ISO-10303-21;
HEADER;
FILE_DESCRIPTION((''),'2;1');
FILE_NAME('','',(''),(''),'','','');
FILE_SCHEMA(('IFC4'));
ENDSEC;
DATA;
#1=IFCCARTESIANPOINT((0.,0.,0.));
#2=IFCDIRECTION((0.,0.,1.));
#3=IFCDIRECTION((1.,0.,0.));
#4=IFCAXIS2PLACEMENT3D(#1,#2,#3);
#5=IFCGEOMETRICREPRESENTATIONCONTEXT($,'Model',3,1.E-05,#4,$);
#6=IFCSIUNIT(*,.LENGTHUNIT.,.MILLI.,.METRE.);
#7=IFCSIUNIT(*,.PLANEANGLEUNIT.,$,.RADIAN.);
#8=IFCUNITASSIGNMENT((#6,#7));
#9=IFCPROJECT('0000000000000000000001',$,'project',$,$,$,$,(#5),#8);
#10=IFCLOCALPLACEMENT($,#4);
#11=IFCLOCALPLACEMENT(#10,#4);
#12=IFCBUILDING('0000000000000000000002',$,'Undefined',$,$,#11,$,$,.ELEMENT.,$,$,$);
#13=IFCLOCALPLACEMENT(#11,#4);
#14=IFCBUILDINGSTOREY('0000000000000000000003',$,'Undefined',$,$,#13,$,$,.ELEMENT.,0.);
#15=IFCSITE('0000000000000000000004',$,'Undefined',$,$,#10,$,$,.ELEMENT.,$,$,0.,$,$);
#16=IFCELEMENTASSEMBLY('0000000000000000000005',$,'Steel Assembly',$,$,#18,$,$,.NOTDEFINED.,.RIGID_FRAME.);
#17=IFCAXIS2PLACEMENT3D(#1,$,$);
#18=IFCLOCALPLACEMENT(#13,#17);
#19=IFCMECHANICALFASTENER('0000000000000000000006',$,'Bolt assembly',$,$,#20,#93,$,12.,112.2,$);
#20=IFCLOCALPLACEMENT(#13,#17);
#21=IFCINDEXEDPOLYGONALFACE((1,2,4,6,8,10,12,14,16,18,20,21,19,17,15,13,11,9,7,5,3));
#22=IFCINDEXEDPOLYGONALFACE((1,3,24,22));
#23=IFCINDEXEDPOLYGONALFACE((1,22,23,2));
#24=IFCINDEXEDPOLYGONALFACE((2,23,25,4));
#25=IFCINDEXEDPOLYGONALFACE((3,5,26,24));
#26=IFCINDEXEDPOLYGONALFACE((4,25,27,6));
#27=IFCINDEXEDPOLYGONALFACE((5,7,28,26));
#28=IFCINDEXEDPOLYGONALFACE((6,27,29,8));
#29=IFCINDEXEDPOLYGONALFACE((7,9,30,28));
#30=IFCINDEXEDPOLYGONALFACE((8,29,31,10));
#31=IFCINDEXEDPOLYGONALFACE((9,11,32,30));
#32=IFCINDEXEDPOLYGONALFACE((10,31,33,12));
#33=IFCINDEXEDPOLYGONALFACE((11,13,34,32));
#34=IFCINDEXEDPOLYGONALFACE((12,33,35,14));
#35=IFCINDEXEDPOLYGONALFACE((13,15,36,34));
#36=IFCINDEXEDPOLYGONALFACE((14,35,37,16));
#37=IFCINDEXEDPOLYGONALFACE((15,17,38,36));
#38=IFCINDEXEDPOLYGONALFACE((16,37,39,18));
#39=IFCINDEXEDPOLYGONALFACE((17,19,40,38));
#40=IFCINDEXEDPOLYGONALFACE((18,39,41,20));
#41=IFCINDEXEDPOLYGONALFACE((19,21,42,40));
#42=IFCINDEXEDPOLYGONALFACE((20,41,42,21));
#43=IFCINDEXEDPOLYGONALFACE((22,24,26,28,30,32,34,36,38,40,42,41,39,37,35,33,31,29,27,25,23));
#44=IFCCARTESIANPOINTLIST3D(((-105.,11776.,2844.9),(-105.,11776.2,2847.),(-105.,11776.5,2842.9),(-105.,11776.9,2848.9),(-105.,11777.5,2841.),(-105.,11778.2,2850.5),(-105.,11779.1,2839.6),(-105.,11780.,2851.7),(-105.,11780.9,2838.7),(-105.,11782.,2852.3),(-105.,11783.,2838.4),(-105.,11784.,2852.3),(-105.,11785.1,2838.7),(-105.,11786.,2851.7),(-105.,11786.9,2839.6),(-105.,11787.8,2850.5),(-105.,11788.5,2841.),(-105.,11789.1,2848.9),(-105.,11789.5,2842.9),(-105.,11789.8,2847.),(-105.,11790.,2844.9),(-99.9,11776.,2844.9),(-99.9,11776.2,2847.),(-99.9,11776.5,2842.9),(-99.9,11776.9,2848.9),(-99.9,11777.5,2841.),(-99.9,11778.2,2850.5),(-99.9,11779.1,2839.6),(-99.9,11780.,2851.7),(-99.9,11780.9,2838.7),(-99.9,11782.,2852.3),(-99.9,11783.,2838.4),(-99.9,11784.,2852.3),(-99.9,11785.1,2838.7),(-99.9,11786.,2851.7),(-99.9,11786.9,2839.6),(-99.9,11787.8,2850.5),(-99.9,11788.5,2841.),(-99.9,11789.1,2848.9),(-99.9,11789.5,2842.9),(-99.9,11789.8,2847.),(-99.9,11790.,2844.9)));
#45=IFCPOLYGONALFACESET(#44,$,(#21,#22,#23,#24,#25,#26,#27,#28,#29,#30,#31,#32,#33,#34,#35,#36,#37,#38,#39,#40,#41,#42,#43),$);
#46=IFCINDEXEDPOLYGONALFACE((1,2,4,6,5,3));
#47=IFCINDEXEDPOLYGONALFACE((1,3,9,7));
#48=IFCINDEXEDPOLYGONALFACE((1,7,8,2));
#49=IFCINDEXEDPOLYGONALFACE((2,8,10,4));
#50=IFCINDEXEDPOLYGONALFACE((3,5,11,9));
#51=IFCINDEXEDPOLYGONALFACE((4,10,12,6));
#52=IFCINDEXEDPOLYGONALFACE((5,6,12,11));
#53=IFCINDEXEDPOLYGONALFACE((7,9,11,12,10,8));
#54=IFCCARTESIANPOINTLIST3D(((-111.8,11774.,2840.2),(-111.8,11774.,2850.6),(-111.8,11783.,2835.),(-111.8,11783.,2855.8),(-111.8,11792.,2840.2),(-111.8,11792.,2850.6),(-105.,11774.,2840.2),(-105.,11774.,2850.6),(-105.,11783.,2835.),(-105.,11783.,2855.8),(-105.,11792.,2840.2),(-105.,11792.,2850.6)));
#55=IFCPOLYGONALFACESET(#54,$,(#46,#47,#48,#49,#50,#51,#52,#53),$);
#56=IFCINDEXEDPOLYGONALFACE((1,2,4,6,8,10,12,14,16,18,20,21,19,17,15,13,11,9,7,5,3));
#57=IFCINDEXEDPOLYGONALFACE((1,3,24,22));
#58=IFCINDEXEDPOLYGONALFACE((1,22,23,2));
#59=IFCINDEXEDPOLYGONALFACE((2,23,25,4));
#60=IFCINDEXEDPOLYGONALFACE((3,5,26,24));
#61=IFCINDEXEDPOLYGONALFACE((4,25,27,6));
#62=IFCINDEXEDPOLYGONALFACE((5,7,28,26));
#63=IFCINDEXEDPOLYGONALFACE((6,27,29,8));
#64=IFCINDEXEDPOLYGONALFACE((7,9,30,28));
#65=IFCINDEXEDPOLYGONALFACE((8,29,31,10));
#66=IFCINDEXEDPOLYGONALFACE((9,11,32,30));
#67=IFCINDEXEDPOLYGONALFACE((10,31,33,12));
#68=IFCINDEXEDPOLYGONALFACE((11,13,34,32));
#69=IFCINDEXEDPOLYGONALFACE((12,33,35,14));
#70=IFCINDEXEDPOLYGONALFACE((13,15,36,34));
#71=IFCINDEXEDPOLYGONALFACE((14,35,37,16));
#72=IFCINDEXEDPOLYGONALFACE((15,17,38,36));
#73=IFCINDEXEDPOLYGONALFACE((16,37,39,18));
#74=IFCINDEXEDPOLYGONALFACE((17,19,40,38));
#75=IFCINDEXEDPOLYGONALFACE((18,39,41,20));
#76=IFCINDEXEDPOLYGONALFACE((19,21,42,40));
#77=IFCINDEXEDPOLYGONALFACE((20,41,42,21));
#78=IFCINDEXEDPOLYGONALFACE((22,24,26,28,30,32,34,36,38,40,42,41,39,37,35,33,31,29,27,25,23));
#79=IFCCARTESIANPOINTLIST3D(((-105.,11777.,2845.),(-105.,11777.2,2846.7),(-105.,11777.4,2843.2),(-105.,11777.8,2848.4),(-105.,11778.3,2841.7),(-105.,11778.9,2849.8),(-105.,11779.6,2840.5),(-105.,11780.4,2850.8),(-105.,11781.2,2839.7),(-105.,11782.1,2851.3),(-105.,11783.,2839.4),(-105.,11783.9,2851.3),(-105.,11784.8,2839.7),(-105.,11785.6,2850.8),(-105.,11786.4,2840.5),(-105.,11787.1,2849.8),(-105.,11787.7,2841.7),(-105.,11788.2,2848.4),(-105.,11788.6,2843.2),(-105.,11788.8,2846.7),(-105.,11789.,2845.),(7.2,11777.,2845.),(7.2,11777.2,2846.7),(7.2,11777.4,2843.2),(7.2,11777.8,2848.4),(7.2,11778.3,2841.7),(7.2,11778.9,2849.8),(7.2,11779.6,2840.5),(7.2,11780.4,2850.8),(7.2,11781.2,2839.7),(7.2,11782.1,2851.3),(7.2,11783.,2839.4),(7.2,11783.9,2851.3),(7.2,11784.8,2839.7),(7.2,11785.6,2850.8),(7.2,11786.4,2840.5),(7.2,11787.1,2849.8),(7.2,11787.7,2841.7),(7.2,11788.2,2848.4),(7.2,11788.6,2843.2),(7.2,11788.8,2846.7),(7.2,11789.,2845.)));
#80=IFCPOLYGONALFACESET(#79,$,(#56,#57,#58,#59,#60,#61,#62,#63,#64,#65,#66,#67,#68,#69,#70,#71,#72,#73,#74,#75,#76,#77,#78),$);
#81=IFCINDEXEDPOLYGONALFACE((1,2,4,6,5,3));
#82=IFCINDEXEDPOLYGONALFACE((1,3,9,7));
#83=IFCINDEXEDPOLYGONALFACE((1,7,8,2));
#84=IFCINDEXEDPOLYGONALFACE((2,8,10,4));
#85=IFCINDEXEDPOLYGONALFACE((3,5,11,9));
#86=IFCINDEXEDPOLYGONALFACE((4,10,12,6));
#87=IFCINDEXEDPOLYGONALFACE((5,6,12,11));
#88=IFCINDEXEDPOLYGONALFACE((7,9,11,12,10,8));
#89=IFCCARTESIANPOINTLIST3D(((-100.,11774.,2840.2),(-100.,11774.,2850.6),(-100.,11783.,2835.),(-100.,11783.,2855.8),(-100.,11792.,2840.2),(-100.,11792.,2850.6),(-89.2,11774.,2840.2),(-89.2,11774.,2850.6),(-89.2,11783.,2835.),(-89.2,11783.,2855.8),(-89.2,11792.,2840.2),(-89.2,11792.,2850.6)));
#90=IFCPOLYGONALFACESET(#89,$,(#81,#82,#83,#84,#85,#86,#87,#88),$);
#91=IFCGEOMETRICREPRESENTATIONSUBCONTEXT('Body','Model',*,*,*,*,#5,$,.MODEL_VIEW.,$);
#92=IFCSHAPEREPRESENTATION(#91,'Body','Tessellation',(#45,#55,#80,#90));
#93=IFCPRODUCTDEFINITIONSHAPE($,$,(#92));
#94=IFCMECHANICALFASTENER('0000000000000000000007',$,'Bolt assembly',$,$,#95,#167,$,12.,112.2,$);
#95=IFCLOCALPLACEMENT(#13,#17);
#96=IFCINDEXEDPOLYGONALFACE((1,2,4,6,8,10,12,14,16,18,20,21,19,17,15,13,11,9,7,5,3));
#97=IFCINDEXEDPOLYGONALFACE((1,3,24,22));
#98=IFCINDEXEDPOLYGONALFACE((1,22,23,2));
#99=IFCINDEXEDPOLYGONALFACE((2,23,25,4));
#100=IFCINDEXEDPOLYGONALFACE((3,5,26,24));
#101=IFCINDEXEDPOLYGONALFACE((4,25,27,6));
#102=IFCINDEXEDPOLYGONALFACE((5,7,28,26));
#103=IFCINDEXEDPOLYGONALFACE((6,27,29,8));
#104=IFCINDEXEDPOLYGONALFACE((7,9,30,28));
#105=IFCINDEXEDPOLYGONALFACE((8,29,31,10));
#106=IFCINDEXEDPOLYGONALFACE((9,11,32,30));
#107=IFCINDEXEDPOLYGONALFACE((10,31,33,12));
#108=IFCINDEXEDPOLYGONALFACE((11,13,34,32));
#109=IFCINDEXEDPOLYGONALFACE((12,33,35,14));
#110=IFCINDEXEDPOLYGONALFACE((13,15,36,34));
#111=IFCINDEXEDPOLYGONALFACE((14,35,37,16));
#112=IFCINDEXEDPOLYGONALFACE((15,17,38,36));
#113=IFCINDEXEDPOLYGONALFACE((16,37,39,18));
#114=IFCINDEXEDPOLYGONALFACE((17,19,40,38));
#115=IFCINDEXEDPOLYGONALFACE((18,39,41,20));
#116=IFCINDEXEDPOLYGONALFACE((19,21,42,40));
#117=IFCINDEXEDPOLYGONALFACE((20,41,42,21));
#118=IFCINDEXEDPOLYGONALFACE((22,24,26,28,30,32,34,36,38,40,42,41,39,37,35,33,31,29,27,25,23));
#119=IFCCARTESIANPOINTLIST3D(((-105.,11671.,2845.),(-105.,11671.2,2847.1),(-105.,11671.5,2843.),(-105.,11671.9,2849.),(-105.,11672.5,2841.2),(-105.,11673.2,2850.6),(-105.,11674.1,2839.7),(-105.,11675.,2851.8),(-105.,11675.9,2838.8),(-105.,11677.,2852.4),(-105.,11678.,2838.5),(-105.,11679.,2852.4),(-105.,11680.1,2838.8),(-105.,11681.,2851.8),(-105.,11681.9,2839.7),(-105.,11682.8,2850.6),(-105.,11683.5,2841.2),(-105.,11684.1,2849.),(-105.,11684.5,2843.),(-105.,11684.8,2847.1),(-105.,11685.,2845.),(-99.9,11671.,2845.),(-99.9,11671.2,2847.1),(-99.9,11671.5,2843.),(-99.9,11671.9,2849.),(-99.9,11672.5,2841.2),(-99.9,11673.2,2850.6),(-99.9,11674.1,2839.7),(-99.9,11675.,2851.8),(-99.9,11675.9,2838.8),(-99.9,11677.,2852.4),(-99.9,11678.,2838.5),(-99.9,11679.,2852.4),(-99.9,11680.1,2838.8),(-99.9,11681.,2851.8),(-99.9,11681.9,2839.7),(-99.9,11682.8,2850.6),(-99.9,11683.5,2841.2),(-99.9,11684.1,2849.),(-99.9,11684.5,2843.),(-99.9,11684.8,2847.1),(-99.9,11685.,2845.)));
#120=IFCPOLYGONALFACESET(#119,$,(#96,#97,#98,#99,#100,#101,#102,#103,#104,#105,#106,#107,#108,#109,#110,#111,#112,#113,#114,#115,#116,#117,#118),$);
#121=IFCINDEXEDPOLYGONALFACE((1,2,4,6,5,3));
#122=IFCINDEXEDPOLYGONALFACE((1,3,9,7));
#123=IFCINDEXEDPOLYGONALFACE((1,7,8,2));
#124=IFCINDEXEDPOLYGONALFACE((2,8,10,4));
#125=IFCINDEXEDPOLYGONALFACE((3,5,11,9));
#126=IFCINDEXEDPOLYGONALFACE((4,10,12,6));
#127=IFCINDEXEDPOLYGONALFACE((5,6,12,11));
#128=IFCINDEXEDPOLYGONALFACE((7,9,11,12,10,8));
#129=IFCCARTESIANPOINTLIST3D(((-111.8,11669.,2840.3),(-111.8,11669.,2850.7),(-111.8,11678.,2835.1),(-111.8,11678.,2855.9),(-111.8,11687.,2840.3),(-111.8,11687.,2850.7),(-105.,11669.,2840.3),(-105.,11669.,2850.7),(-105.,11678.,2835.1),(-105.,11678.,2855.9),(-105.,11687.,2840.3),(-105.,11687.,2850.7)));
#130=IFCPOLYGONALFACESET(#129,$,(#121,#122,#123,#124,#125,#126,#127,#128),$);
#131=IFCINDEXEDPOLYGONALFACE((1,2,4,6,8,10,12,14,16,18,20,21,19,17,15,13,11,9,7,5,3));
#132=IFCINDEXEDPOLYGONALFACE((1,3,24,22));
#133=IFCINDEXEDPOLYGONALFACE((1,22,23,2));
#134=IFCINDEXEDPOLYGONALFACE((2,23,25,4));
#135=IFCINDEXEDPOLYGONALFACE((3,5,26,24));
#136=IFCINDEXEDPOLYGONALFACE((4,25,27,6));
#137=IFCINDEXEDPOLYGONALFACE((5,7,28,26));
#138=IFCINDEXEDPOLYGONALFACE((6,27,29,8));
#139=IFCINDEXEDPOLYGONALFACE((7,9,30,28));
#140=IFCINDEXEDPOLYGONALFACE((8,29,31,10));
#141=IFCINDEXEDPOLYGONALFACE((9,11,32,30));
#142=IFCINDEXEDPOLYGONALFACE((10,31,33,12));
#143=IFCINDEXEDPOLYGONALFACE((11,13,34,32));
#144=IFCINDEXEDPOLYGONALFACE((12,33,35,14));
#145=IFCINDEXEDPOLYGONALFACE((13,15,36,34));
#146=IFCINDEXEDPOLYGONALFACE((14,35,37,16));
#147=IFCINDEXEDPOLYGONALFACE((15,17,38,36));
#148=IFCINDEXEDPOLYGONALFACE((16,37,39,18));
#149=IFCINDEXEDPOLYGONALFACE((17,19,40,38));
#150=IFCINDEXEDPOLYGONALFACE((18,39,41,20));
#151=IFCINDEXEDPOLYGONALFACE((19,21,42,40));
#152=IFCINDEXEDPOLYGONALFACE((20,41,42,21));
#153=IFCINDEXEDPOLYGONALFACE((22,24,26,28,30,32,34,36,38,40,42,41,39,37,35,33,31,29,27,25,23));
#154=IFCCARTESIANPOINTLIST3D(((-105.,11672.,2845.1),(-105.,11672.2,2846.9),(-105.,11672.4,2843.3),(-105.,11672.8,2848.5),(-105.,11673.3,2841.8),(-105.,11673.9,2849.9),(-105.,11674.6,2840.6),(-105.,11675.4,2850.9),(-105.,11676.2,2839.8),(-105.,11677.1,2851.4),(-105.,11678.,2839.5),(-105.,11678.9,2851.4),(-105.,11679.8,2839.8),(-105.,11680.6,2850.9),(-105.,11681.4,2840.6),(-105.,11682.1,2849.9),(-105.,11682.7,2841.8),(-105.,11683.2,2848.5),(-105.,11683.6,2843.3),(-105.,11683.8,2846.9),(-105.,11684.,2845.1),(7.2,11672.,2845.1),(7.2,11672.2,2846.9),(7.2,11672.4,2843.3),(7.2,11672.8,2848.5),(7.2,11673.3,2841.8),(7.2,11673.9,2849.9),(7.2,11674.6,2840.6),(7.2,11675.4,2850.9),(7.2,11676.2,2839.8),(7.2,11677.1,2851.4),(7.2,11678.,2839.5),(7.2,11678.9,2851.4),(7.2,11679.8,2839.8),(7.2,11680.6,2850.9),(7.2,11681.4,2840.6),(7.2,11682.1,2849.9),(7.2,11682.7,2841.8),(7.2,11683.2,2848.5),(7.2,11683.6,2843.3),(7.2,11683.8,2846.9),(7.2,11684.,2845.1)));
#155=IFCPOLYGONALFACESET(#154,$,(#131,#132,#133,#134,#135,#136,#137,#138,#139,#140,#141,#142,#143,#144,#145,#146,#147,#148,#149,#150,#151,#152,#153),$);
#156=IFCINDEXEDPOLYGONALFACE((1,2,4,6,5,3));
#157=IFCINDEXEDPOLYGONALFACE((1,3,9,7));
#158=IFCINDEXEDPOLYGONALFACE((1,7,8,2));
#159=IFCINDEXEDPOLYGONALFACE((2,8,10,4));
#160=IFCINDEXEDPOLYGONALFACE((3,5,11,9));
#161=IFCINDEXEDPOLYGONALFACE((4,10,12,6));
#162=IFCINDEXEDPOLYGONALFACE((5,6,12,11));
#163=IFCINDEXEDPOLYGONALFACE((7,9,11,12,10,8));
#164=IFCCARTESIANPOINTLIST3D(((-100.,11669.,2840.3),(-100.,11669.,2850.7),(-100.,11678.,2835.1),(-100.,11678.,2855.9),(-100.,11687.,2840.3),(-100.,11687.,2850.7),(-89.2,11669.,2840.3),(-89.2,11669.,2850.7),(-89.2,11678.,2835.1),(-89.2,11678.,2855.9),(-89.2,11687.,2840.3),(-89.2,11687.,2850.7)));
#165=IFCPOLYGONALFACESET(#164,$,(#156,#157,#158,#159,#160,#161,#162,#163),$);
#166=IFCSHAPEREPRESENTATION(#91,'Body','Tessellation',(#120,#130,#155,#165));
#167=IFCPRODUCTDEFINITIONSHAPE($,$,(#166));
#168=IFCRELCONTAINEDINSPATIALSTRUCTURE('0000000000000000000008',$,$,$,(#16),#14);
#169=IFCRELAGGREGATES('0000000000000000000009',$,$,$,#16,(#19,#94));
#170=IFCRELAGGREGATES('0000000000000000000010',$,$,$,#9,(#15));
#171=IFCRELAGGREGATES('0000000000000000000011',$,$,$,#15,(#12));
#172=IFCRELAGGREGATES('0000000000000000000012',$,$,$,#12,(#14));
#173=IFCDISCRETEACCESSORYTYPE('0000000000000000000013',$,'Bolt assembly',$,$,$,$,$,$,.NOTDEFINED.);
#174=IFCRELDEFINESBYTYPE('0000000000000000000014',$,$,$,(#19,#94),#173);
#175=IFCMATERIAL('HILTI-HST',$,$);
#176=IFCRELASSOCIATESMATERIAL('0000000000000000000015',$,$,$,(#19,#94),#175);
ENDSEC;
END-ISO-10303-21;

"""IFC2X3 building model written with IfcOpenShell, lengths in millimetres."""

from ifc_helpers import new_model, si_unit, frame, origin_with_axes, origin_2d_with_axis, place, context, subcontext, project, spatial, polyline, circle, outline, extrude, source, transform, mapped, material, type_object, element, aggregate, save


model = new_model("IFC2X3")

# Units and contexts
model_context = context("Model", 3, precision=1e-05, world=origin_with_axes())
body_context = subcontext(model_context, "Body", "Model", "MODEL_VIEW")
ifc_project = project(units=[si_unit("LENGTHUNIT", "METRE", prefix="MILLI"), si_unit("PLANEANGLEUNIT", "RADIAN")], contexts=[model_context])

# Site, building, storey
site_placement = place(None, origin_with_axes())
site = spatial("IfcSite", under=ifc_project, at=site_placement, Name="Undefined", CompositionType="ELEMENT", RefElevation=0.0)
building_placement = place(site_placement, origin_with_axes())
building = spatial("IfcBuilding", under=site, at=building_placement, Name="Undefined", CompositionType="ELEMENT")
storey_placement = place(building_placement, origin_with_axes())
storey = spatial("IfcBuildingStorey", under=building, at=storey_placement, Name="Undefined", CompositionType="ELEMENT", Elevation=0.0)

# Element assembly
assembly_1_placement = place(storey_placement, origin_with_axes())
assembly_1 = element("IfcElementAssembly", 1, at=assembly_1_placement, inside=storey, Name="Steel Assembly", AssemblyPlace="NOTDEFINED", PredefinedType="RIGID_FRAME")

# Shared definitions
discrete_accessory_type_1 = type_object("IfcDiscreteAccessoryType", Name="Bolt assembly")

# Mechanical fasteners
ifc_material_1 = material(Name="HILTI-HST")
shared_shape_1 = source(origin_with_axes(), body_context, "Body", "SweptSolid", [
    extrude(circle(Radius=7.0, at=origin_2d_with_axis()), frame((0.0, -5.0, 0.0), z_axis=(0.0, 1.0, 0.0), x_axis=(1.0, 0.0, 0.0)), (0.0, 0.0, 1.0), 5.1),
    extrude(outline(polyline([(10.4, 0.0), (5.2, 9.0), (-5.2, 9.0), (-10.4, 0.0), (-5.2, -9.0), (5.2, -9.0), (10.4, 0.0)])), frame((0.0, -11.8, 0.0), z_axis=(0.0, 1.0, 0.0), x_axis=(1.0, 0.0, 0.0)), (0.0, 0.0, 1.0), 6.8),
    extrude(circle(Radius=6.0, at=origin_2d_with_axis()), frame((0.0, -5.0, 0.0), z_axis=(0.0, 1.0, 0.0), x_axis=(1.0, 0.0, 0.0)), (0.0, 0.0, 1.0), 112.2),
    extrude(outline(polyline([(10.4, 0.0), (5.2, 9.0), (-5.2, 9.0), (-10.4, 0.0), (-5.2, -9.0), (5.2, -9.0), (10.4, 0.0)])), frame((0.0, 0.0, 0.0), z_axis=(0.0, 1.0, 0.0), x_axis=(1.0, 0.0, 0.0)), (0.0, 0.0, 1.0), 10.8),
])
mechanical_fastener_1_placement = place(assembly_1_placement, frame((-100.0, 11783.0, 2845.4), z_axis=(0.0, -1.0, 0.0), x_axis=(0.0, 0.0, -1.0)))
mechanical_fastener_1 = element("IfcMechanicalFastener", 2, at=mechanical_fastener_1_placement, type_object=discrete_accessory_type_1, material=ifc_material_1, Name="Bolt assembly", NominalDiameter=12.0, NominalLength=112.2, context=body_context, shape_type="MappedRepresentation", body=[
    mapped(shared_shape_1, transform((0.0, 0.0, 0.0))),
])
mechanical_fastener_2_placement = place(assembly_1_placement, frame((-100.0, 11678.0, 2845.5), z_axis=(0.0, -1.0, 0.0), x_axis=(0.0, 0.0, -1.0)))
mechanical_fastener_2 = element("IfcMechanicalFastener", 3, at=mechanical_fastener_2_placement, type_object=discrete_accessory_type_1, material=ifc_material_1, Name="Bolt assembly", NominalDiameter=12.0, NominalLength=112.2, context=body_context, shape_type="MappedRepresentation", body=[
    mapped(shared_shape_1, transform((0.0, 0.0, 0.0))),
])
aggregate(assembly_1, [mechanical_fastener_1, mechanical_fastener_2])

save(model, "model.ifc")
